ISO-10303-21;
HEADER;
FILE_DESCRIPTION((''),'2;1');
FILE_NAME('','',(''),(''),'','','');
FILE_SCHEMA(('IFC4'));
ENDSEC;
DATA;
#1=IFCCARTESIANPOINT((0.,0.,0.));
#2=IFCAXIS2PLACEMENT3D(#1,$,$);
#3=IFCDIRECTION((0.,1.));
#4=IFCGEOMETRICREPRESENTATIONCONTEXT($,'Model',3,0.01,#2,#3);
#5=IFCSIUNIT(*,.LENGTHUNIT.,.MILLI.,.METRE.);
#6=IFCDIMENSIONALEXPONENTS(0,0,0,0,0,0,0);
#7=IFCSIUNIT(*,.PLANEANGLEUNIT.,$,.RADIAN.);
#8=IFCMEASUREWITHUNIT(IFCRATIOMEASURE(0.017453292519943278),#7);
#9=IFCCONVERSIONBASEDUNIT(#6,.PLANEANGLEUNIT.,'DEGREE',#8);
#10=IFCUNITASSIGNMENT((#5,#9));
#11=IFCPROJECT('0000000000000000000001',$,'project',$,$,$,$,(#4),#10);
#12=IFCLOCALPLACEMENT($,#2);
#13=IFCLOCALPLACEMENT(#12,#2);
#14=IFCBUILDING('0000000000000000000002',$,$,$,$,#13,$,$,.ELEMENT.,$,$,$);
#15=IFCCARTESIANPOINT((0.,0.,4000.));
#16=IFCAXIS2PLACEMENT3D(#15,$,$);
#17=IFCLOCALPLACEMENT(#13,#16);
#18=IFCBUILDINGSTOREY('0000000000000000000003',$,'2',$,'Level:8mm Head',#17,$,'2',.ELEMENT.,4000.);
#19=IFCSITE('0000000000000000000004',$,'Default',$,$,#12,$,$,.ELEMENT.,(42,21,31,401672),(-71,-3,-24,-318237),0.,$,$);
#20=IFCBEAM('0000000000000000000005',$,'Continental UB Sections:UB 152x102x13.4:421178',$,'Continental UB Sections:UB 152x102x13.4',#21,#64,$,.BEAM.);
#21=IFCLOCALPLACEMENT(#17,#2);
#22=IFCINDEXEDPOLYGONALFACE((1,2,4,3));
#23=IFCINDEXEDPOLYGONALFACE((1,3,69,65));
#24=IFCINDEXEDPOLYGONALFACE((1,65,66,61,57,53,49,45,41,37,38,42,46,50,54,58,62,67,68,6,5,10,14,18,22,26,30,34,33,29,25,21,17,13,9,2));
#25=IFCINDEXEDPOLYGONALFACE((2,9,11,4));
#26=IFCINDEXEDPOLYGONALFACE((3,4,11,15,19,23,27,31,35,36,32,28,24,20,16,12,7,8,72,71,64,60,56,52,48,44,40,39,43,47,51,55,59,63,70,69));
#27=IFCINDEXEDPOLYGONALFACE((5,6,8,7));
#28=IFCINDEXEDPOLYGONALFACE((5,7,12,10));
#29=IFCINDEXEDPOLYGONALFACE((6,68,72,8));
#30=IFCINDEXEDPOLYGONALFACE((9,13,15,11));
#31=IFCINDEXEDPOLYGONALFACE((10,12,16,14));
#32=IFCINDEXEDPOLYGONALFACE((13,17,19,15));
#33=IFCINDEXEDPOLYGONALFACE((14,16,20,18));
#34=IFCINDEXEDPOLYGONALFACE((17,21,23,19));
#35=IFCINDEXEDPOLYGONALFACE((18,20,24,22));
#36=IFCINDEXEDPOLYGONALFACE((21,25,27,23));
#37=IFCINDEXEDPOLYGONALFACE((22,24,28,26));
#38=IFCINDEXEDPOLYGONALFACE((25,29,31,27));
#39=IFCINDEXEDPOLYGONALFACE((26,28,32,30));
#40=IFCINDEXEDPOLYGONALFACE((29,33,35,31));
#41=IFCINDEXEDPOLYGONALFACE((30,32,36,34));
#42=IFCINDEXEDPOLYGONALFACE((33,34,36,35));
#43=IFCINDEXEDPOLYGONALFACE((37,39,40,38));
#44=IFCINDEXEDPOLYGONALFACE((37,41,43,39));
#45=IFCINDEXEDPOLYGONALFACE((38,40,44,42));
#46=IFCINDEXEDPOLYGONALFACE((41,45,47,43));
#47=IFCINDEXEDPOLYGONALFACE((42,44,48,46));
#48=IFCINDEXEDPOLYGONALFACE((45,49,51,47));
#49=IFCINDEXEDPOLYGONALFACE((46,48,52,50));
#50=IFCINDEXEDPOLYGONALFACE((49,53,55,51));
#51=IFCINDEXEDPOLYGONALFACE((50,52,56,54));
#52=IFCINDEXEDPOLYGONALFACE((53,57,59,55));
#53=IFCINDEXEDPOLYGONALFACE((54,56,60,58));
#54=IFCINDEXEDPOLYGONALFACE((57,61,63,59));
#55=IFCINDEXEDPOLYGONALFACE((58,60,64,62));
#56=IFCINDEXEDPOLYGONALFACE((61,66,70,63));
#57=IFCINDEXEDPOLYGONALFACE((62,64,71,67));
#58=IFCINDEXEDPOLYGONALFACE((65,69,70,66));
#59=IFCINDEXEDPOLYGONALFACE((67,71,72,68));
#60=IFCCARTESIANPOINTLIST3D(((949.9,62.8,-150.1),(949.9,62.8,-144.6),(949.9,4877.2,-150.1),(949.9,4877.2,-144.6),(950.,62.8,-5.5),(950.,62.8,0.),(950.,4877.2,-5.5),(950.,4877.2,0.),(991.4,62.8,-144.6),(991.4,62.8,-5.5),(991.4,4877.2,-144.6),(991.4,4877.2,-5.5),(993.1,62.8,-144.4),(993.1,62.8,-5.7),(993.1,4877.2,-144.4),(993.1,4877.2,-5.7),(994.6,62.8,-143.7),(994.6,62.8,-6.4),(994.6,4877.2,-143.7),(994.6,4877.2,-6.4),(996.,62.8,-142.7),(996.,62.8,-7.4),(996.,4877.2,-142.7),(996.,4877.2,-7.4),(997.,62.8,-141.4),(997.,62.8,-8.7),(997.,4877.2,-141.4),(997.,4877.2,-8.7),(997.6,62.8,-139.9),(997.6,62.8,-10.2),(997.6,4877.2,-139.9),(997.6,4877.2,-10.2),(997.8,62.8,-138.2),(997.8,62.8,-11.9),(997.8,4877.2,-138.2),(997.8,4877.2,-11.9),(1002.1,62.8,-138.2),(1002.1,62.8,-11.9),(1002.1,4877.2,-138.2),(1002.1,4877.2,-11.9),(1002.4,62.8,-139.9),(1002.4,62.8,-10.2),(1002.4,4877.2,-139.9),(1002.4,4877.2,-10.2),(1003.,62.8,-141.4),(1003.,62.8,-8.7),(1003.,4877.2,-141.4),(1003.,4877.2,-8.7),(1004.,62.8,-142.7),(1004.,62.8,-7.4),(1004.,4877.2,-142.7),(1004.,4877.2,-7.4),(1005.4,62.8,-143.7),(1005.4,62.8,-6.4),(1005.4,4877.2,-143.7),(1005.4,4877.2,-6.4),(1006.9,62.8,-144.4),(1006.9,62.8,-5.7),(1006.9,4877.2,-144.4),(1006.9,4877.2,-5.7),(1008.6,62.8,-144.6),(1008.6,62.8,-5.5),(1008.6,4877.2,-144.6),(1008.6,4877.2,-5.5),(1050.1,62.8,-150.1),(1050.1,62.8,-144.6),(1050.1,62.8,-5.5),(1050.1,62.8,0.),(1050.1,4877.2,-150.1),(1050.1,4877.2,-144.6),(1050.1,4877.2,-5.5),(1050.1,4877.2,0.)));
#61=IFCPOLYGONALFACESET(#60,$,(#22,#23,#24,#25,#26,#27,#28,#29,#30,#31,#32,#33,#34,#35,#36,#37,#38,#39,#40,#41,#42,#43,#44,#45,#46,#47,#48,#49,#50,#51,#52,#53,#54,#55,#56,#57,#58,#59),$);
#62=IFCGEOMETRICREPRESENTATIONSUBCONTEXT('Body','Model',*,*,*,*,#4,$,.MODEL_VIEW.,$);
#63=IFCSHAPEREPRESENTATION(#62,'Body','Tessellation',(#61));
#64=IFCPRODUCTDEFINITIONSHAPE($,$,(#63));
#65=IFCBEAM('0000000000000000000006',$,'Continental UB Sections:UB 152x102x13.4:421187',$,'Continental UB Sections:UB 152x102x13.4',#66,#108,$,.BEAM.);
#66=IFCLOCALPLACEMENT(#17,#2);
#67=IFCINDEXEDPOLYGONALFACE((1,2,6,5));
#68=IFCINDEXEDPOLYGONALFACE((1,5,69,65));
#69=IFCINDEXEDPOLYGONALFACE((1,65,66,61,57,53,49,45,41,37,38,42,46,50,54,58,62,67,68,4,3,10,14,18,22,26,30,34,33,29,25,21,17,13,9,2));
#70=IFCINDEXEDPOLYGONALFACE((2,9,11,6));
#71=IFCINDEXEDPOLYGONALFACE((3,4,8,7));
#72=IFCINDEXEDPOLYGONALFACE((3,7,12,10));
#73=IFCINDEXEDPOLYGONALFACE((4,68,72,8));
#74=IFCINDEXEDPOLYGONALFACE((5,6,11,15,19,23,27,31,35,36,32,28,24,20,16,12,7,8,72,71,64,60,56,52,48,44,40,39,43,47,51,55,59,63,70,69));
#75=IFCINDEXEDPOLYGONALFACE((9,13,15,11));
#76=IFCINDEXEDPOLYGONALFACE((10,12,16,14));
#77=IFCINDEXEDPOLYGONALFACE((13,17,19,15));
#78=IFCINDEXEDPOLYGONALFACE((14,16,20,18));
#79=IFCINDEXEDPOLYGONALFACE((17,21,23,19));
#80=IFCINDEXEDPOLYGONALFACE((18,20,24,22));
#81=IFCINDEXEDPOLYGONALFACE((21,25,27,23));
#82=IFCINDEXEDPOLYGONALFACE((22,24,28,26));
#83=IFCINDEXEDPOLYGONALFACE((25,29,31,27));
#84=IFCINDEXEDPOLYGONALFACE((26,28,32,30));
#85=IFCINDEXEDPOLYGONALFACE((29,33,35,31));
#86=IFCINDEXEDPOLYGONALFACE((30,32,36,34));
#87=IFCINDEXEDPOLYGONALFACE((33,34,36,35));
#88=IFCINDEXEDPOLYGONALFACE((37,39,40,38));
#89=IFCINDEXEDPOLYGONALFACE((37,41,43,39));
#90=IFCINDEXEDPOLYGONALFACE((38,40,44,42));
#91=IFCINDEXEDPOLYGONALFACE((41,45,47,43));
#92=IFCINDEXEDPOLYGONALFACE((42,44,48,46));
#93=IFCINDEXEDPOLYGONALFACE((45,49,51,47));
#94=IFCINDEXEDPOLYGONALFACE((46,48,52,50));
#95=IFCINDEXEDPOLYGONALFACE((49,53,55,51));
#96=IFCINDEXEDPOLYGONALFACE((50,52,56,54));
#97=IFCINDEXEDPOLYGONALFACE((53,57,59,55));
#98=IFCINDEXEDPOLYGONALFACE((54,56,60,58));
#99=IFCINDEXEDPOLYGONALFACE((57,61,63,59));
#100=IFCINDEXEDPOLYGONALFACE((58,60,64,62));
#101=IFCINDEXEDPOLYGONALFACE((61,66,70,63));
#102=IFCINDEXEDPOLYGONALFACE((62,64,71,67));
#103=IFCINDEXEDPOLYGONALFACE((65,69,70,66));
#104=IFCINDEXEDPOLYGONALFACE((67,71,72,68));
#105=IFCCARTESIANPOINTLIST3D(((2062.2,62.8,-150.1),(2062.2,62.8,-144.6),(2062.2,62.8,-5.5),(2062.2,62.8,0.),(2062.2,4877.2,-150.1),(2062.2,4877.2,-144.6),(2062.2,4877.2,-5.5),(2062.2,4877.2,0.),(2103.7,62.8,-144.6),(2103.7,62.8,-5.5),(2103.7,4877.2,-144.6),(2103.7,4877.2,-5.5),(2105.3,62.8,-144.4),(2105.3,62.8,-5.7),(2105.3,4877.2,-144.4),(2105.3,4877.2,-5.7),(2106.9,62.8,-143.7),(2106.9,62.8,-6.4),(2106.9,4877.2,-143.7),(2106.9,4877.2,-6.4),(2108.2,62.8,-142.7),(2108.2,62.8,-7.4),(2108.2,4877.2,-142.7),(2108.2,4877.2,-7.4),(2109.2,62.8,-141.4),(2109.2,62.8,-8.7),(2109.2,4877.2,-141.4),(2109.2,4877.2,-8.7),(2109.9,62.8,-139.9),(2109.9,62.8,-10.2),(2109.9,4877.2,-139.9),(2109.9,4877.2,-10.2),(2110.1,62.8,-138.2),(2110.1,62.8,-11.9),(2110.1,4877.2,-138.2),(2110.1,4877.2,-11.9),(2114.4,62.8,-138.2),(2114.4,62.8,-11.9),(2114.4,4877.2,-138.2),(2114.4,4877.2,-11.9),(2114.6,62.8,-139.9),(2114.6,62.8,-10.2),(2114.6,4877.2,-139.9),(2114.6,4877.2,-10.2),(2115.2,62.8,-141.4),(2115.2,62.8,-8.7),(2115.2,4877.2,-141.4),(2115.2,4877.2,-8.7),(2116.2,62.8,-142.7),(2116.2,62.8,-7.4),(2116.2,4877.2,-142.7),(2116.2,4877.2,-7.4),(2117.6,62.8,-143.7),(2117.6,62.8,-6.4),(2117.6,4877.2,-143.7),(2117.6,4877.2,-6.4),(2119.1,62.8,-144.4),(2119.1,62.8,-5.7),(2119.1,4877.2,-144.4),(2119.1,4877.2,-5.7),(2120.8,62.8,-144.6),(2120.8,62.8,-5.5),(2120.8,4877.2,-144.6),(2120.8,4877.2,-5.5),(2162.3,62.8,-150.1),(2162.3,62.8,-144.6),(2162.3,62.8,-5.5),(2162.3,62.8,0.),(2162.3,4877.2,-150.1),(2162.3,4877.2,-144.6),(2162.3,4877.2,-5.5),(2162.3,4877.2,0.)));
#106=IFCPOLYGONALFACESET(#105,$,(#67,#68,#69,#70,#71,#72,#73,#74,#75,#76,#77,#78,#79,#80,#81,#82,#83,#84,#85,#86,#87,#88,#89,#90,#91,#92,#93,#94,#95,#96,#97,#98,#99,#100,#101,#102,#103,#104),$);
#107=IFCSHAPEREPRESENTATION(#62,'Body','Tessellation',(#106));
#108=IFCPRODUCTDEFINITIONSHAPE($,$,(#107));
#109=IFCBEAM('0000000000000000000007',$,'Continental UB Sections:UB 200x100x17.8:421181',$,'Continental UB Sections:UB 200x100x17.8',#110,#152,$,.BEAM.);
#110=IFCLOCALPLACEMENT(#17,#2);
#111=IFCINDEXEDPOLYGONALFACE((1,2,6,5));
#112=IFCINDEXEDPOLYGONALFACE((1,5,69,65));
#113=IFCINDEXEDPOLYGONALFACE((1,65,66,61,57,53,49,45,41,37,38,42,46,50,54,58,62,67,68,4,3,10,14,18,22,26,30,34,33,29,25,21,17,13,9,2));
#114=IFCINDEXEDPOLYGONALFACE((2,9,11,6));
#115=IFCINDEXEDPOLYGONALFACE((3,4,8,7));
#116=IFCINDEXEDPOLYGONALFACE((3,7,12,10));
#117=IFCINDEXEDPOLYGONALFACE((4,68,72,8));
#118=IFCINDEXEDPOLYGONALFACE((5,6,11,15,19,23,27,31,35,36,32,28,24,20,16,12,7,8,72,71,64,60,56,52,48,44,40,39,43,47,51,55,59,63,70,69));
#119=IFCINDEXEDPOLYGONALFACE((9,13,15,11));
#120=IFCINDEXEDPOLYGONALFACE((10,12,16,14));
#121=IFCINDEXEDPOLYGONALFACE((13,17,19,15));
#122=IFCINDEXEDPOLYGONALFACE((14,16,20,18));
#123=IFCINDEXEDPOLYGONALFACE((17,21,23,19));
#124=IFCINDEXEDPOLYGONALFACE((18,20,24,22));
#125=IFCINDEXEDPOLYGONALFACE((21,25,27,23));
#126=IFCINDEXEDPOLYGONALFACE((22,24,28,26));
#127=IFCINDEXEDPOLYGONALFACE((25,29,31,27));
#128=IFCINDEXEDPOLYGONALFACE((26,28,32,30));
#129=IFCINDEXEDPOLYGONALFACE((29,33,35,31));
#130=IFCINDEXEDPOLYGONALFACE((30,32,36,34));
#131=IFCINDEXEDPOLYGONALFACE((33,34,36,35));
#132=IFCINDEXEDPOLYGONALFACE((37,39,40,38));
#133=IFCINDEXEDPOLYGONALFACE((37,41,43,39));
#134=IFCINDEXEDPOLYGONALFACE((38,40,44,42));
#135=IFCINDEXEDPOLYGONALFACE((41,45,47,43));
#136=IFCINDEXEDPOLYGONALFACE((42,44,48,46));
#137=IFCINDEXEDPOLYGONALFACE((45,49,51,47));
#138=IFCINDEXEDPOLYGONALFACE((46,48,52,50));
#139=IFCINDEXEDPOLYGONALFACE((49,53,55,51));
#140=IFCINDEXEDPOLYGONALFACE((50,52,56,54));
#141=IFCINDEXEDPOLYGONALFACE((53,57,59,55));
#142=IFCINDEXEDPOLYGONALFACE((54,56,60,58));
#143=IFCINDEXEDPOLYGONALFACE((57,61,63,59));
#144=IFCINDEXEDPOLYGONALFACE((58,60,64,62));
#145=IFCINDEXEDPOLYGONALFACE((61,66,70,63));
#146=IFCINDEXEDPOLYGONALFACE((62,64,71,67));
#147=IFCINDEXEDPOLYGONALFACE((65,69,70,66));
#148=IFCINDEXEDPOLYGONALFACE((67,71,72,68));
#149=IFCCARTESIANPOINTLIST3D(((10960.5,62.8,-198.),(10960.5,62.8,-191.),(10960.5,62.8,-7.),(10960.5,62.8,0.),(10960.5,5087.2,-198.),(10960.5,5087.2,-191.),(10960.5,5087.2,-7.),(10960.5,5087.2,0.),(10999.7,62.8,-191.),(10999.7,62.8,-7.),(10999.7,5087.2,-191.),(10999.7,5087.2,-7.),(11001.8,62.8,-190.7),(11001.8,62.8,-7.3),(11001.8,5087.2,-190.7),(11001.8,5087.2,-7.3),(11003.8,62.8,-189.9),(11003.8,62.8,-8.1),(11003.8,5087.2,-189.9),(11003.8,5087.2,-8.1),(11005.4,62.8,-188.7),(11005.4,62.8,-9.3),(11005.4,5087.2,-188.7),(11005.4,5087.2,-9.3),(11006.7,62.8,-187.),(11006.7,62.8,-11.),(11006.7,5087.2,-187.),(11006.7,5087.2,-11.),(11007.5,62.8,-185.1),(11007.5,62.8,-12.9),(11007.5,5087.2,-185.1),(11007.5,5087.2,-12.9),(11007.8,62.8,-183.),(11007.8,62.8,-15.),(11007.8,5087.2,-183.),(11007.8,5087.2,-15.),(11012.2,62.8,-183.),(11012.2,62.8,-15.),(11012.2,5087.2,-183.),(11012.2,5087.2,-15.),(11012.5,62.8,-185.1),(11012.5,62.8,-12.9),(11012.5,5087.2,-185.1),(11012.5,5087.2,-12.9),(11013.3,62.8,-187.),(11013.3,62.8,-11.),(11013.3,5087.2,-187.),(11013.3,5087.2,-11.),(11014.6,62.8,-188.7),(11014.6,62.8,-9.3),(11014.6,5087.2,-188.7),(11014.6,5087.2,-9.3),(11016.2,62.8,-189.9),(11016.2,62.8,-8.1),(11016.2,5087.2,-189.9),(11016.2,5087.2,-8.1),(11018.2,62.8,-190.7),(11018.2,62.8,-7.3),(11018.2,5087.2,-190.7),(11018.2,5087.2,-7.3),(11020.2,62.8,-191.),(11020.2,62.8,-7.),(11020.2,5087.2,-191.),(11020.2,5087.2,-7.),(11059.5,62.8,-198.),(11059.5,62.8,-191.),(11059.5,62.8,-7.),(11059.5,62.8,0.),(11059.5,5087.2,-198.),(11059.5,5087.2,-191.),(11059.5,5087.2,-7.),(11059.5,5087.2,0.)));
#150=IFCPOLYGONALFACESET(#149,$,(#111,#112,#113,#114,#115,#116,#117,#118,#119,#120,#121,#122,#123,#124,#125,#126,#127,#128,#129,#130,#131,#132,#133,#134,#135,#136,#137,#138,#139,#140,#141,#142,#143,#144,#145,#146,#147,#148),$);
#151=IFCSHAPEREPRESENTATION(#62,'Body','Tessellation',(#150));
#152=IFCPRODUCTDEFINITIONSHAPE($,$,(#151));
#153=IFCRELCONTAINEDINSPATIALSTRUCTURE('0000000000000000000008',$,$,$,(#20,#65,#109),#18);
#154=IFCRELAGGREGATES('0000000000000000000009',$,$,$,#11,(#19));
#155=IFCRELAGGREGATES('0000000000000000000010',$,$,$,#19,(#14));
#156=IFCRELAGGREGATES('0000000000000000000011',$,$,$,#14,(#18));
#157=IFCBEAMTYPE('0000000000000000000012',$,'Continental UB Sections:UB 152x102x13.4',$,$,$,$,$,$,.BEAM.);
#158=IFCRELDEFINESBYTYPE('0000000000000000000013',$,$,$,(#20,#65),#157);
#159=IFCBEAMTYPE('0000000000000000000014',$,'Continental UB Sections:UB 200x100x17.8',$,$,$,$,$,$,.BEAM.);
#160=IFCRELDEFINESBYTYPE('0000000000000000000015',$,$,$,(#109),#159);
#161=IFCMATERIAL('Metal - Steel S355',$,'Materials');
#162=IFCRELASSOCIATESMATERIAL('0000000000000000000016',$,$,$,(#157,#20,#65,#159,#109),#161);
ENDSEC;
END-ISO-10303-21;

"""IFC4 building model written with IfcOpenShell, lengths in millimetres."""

from ifc_helpers import new_model, entity, si_unit, converted_unit, direction, frame, origin, place, context, subcontext, project, spatial, line, arc, indexed_curve, outline, extrude, source, transform, mapped, material, type_object, type_shapes, element, save


model = new_model("IFC4")

# Units and contexts
model_context = context("Model", 3, precision=0.01, world=origin(), true_north=direction((0.0, 1.0)))
body_context = subcontext(model_context, "Body", "Model", "MODEL_VIEW")
ifc_project = project(units=[si_unit("LENGTHUNIT", "METRE", prefix="MILLI"), converted_unit("PLANEANGLEUNIT", "DEGREE", entity("IfcRatioMeasure", 0.017453292519943278), si_unit("PLANEANGLEUNIT", "RADIAN"), dimensions=[0, 0, 0, 0, 0, 0, 0])], contexts=[model_context])

# Site, building, storey
site_placement = place(None, origin())
site = spatial("IfcSite", under=ifc_project, at=site_placement, Name="Default", CompositionType="ELEMENT", RefLatitude=(42, 21, 31, 401672), RefLongitude=(-71, -3, -24, -318237), RefElevation=0.0)
building_placement = place(site_placement, origin())
building = spatial("IfcBuilding", under=site, at=building_placement, CompositionType="ELEMENT")
storey_placement = place(building_placement, frame((0.0, 0.0, 4000.0)))
storey = spatial("IfcBuildingStorey", under=building, at=storey_placement, Name="2", ObjectType="Level:8mm Head", LongName="2", CompositionType="ELEMENT", Elevation=4000.0)

# Beams
ifc_material_1 = material(Name="Metal - Steel S355", Category="Materials")
beam_type_1 = type_object("IfcBeamType", Name="Continental UB Sections:UB 152x102x13.4", PredefinedType="BEAM", material=ifc_material_1)
shared_shape_1 = source(origin(), body_context, "Body", "SweptSolid", [
    extrude(outline(indexed_curve([(-75.0, -50.1), (-69.6, -50.1), (-69.6, -8.5), (-67.7, -4.0), (-63.2, -2.1), (63.1, -2.1), (67.7, -4.0), (69.5, -8.5), (69.5, -50.1), (75.1, -50.1), (75.1, 50.1), (69.5, 50.1), (69.5, 8.6), (67.7, 4.0), (63.1, 2.2), (-63.2, 2.2), (-67.7, 4.0), (-69.6, 8.6), (-69.6, 50.0), (-75.0, 50.0)], segments=[line(1, 2, 3), arc(3, 4, 5), line(5, 6), arc(6, 7, 8), line(8, 9, 10, 11, 12, 13), arc(13, 14, 15), line(15, 16), arc(16, 17, 18), line(18, 19, 20, 1)], self_intersect=False)), frame((-2487.2, 0.0, 0.0), z_axis=(1.0, 0.0, 0.0), x_axis=(0.0, 0.0, -1.0)), (0.0, 0.0, 1.0), 4814.4),
])
type_shapes(beam_type_1, [shared_shape_1])
for number, where, z_axis, x_axis, name in (
    (1, (1000.0, 2550.0, -75.1), (0.0, 0.0, 1.0), (0.0, 1.0, 0.0), "Continental UB Sections:UB 152x102x13.4:421178"),
    (2, (2112.2, 2550.0, -75.1), (0.0, 0.0, 1.0), (0.0, 1.0, 0.0), "Continental UB Sections:UB 152x102x13.4:421187"),
):
    element("IfcBeam", number, at=place(storey_placement, frame(where, z_axis=z_axis, x_axis=x_axis)), inside=storey, type_object=beam_type_1, material=ifc_material_1, Name=name, ObjectType="Continental UB Sections:UB 152x102x13.4", PredefinedType="BEAM", context=body_context, shape_type="MappedRepresentation", body=[
        mapped(shared_shape_1, transform((0.0, 0.0, 0.0), scale=1.0)),
    ])
beam_type_2 = type_object("IfcBeamType", Name="Continental UB Sections:UB 200x100x17.8", PredefinedType="BEAM", material=ifc_material_1)
shared_shape_2 = source(origin(), body_context, "Body", "SweptSolid", [
    extrude(outline(indexed_curve([(-99.0, -49.5), (-92.0, -49.5), (-92.0, -10.2), (-89.7, -4.6), (-84.0, -2.2), (84.0, -2.2), (89.7, -4.6), (92.0, -10.2), (92.0, -49.5), (99.0, -49.5), (99.0, 49.5), (92.0, 49.5), (92.0, 10.3), (89.7, 4.6), (84.0, 2.3), (-84.0, 2.3), (-89.7, 4.6), (-92.0, 10.3), (-92.0, 49.5), (-99.0, 49.5)], segments=[line(1, 2, 3), arc(3, 4, 5), line(5, 6), arc(6, 7, 8), line(8, 9, 10, 11, 12, 13), arc(13, 14, 15), line(15, 16), arc(16, 17, 18), line(18, 19, 20, 1)], self_intersect=False)), frame((-2487.2, 0.0, 0.0), z_axis=(1.0, 0.0, 0.0), x_axis=(0.0, 0.0, -1.0)), (0.0, 0.0, 1.0), 5024.4),
])
type_shapes(beam_type_2, [shared_shape_2])
beam_1_placement = place(storey_placement, frame((11010.0, 2550.0, -99.0), z_axis=(0.0, 0.0, 1.0), x_axis=(0.0, 1.0, 0.0)))
element("IfcBeam", 3, at=beam_1_placement, inside=storey, type_object=beam_type_2, material=ifc_material_1, Name="Continental UB Sections:UB 200x100x17.8:421181", ObjectType="Continental UB Sections:UB 200x100x17.8", PredefinedType="BEAM", context=body_context, shape_type="MappedRepresentation", body=[
    mapped(shared_shape_2, transform((0.0, 0.0, 0.0), scale=1.0)),
])

save(model, "model.ifc")
